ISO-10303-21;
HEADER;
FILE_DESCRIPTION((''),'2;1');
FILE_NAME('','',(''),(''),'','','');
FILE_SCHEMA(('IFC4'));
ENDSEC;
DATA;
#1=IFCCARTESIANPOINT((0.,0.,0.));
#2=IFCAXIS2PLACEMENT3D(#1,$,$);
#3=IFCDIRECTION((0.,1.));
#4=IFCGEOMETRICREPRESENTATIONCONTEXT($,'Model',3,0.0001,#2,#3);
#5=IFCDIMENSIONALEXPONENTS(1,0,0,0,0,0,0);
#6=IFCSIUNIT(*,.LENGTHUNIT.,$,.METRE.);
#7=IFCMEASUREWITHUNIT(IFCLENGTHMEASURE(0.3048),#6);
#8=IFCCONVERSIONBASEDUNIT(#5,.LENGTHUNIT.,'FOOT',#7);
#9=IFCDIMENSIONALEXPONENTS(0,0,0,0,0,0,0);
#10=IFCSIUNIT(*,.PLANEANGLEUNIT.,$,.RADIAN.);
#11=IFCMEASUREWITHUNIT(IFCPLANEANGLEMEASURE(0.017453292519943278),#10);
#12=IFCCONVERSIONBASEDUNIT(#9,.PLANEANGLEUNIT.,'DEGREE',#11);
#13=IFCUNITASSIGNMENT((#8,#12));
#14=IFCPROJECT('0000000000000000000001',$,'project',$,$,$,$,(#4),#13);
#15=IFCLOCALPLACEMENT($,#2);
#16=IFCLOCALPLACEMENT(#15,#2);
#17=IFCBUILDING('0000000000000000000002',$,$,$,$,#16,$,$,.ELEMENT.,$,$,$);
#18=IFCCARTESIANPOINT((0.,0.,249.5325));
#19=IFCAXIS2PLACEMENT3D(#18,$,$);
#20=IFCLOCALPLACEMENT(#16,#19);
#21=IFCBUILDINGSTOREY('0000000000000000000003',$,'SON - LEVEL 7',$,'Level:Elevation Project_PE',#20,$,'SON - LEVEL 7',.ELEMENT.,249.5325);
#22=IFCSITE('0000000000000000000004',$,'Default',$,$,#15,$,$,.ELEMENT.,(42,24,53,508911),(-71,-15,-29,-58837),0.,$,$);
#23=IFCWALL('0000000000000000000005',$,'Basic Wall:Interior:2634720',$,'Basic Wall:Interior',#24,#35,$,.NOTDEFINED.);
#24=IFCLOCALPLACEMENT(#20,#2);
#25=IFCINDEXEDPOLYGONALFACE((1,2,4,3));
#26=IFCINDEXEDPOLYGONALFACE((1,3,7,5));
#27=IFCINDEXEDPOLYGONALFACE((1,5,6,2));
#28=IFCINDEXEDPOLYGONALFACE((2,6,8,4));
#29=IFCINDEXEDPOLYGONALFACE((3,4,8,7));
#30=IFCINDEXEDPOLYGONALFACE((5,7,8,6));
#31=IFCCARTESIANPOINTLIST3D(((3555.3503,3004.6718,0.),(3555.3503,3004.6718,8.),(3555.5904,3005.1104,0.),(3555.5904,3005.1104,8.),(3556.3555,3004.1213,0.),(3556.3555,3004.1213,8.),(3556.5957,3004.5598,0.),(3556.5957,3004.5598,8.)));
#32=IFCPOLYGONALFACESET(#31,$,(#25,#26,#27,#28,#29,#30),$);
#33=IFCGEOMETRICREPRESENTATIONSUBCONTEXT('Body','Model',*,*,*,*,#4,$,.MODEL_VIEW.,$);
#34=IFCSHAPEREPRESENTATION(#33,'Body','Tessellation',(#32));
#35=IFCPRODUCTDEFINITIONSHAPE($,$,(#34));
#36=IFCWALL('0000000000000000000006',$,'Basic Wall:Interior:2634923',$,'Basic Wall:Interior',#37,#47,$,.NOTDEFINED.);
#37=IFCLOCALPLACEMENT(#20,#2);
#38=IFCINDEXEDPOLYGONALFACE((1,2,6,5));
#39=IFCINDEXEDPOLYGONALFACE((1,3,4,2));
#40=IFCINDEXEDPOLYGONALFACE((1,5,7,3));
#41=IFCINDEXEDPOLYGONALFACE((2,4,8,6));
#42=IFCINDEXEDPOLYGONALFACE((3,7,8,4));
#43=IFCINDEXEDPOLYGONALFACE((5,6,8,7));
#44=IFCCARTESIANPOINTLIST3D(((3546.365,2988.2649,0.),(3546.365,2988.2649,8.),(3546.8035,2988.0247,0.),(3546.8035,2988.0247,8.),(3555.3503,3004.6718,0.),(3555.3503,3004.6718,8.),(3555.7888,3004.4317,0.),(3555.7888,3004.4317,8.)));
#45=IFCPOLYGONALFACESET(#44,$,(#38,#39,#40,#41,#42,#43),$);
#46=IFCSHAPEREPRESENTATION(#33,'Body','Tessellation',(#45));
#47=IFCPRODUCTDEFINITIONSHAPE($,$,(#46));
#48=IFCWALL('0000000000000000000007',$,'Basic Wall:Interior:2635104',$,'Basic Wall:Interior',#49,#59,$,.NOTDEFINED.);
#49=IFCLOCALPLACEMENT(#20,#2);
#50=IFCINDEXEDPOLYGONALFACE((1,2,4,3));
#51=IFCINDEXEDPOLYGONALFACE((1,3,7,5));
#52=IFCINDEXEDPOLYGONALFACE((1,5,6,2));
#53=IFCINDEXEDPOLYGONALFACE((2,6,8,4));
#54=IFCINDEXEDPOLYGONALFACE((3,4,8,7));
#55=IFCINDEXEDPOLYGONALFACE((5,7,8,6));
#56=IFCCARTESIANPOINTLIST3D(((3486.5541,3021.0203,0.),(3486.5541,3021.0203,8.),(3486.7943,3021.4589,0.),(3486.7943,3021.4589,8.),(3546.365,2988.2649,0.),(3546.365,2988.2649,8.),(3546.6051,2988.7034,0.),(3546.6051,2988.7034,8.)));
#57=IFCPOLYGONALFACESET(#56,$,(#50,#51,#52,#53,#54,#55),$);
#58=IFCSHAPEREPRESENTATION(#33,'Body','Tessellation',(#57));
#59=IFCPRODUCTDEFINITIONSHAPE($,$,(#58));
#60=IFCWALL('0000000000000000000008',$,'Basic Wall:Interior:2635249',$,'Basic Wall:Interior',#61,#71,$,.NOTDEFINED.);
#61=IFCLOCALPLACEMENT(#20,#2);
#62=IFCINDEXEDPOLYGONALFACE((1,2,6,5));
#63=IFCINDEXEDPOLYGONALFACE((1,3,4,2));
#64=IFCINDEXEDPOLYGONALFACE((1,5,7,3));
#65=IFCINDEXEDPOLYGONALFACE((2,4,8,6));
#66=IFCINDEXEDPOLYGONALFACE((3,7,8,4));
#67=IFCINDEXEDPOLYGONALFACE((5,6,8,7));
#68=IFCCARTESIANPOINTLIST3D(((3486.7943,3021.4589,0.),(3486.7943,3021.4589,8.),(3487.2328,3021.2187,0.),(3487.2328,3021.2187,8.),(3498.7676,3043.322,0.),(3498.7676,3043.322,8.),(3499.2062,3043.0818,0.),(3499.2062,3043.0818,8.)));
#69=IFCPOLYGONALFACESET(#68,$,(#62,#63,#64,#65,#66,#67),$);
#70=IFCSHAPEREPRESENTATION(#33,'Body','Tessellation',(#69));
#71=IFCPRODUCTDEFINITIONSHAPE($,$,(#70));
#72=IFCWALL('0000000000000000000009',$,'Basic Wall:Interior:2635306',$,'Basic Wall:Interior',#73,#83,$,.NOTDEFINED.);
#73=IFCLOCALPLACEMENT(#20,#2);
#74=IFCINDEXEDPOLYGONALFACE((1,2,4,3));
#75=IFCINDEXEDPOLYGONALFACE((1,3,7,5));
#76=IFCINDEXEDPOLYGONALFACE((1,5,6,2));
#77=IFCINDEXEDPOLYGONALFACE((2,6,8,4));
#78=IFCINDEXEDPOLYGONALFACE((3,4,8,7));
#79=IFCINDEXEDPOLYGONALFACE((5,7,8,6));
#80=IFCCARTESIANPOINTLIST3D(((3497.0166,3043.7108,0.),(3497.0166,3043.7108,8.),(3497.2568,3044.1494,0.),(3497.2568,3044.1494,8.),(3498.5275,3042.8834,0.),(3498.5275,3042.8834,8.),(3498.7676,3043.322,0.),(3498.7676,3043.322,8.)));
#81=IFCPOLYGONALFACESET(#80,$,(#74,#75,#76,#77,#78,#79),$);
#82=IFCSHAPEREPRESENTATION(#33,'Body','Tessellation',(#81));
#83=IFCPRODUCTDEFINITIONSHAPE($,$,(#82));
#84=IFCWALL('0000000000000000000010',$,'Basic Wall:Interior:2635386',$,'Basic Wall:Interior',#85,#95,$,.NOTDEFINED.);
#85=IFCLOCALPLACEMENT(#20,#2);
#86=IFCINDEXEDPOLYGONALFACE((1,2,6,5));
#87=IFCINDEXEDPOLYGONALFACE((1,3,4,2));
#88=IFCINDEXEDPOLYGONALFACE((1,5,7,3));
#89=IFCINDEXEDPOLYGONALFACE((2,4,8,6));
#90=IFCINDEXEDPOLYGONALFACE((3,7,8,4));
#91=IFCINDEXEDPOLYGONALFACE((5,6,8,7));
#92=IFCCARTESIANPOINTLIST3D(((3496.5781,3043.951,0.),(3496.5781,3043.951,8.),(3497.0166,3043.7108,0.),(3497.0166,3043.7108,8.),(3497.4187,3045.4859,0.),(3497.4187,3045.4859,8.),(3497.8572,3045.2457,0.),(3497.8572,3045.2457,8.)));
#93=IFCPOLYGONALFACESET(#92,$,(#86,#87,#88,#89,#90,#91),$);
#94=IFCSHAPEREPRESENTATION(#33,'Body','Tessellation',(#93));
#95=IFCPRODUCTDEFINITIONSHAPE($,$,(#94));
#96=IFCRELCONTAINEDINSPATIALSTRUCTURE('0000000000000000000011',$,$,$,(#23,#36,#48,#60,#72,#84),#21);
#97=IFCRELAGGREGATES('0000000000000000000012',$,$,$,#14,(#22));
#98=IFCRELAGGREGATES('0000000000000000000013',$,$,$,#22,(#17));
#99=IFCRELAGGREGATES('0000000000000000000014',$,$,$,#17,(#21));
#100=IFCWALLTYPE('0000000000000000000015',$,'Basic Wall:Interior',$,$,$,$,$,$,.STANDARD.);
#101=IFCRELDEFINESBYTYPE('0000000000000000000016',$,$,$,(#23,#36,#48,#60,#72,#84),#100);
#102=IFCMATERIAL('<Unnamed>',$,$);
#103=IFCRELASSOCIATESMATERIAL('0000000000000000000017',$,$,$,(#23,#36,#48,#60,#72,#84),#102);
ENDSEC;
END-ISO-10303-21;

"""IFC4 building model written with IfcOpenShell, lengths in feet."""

from ifc_helpers import new_model, entity, si_unit, converted_unit, direction, frame, origin, place, context, subcontext, project, spatial, indexed_curve, outline, extrude, material, type_object, element, save


model = new_model("IFC4")

# Units and contexts
model_context = context("Model", 3, precision=0.0001, world=origin(), true_north=direction((0.0, 1.0)))
body_context = subcontext(model_context, "Body", "Model", "MODEL_VIEW")
ifc_project = project(units=[converted_unit("LENGTHUNIT", "FOOT", entity("IfcLengthMeasure", 0.3048), si_unit("LENGTHUNIT", "METRE"), dimensions=[1, 0, 0, 0, 0, 0, 0]), converted_unit("PLANEANGLEUNIT", "DEGREE", entity("IfcPlaneAngleMeasure", 0.017453292519943278), si_unit("PLANEANGLEUNIT", "RADIAN"), dimensions=[0, 0, 0, 0, 0, 0, 0])], contexts=[model_context])

# Site, building, storey
site_placement = place(None, origin())
site = spatial("IfcSite", under=ifc_project, at=site_placement, Name="Default", CompositionType="ELEMENT", RefLatitude=(42, 24, 53, 508911), RefLongitude=(-71, -15, -29, -58837), RefElevation=0.0)
building_placement = place(site_placement, origin())
building = spatial("IfcBuilding", under=site, at=building_placement, CompositionType="ELEMENT")
storey_placement = place(building_placement, frame((0.0, 0.0, 249.5325)))
storey = spatial("IfcBuildingStorey", under=building, at=storey_placement, Name="SON - LEVEL 7", ObjectType="Level:Elevation Project_PE", LongName="SON - LEVEL 7", CompositionType="ELEMENT", Elevation=249.5325)

# Walls
ifc_material = material(Name="<Unnamed>")
wall_type = type_object("IfcWallType", Name="Basic Wall:Interior", PredefinedType="STANDARD")
wall_1_placement = place(storey_placement, frame((3556.4756, 3004.3406, 0.0), z_axis=(0.0, 0.0, 1.0), x_axis=(-0.877084, 0.480336, 0.0)))
element("IfcWall", 1, at=wall_1_placement, inside=storey, type_object=wall_type, material=ifc_material, Name="Basic Wall:Interior:2634720", ObjectType="Basic Wall:Interior", PredefinedType="NOTDEFINED", context=body_context, shape_type="SweptSolid", body=[
    extrude(outline(indexed_curve([(1.1461, 0.25), (0.0, 0.25), (0.0, -0.25), (1.1461, -0.25), (1.1461, 0.25)], self_intersect=False)), origin(), (0.0, 0.0, 1.0), 8.0),
])
wall_2_placement = place(storey_placement, frame((3555.5695, 3004.5517, 0.0), z_axis=(0.0, 0.0, 1.0), x_axis=(-0.480336, -0.877084, 0.0)))
element("IfcWall", 2, at=wall_2_placement, inside=storey, type_object=wall_type, material=ifc_material, Name="Basic Wall:Interior:2634923", ObjectType="Basic Wall:Interior", PredefinedType="NOTDEFINED", context=body_context, shape_type="SweptSolid", body=[
    extrude(outline(indexed_curve([(18.7063, 0.25), (0.0, 0.25), (0.0, -0.25), (18.7063, -0.25), (18.7063, 0.25)], self_intersect=False)), origin(), (0.0, 0.0, 1.0), 8.0),
])
wall_3_placement = place(storey_placement, frame((3546.485, 2988.4841, 0.0), z_axis=(0.0, 0.0, 1.0), x_axis=(-0.877084, 0.480336, 0.0)))
element("IfcWall", 3, at=wall_3_placement, inside=storey, type_object=wall_type, material=ifc_material, Name="Basic Wall:Interior:2635104", ObjectType="Basic Wall:Interior", PredefinedType="NOTDEFINED", context=body_context, shape_type="SweptSolid", body=[
    extrude(outline(indexed_curve([(68.1928, 0.25), (0.0, 0.25), (0.0, -0.25), (68.1928, -0.25), (68.1928, 0.25)], self_intersect=False)), origin(), (0.0, 0.0, 1.0), 8.0),
])
wall_4_placement = place(storey_placement, frame((3487.0136, 3021.3388, 0.0), z_axis=(0.0, 0.0, 1.0), x_axis=(0.480336, 0.877084, 0.0)))
element("IfcWall", 4, at=wall_4_placement, inside=storey, type_object=wall_type, material=ifc_material, Name="Basic Wall:Interior:2635249", ObjectType="Basic Wall:Interior", PredefinedType="NOTDEFINED", context=body_context, shape_type="SweptSolid", body=[
    extrude(outline(indexed_curve([(24.927, 0.25), (0.0, 0.25), (0.0, -0.25), (24.927, -0.25), (24.927, 0.25)], self_intersect=False)), origin(), (0.0, 0.0, 1.0), 8.0),
])
wall_5_placement = place(storey_placement, frame((3498.6476, 3043.1027, 0.0), z_axis=(0.0, 0.0, 1.0), x_axis=(-0.877084, 0.480336, 0.0)))
element("IfcWall", 5, at=wall_5_placement, inside=storey, type_object=wall_type, material=ifc_material, Name="Basic Wall:Interior:2635306", ObjectType="Basic Wall:Interior", PredefinedType="NOTDEFINED", context=body_context, shape_type="SweptSolid", body=[
    extrude(outline(indexed_curve([(1.7226, 0.25), (0.0, 0.25), (0.0, -0.25), (1.7226, -0.25), (1.7226, 0.25)], self_intersect=False)), origin(), (0.0, 0.0, 1.0), 8.0),
])
wall_6_placement = place(storey_placement, frame((3496.7974, 3043.8309, 0.0), z_axis=(0.0, 0.0, 1.0), x_axis=(0.480336, 0.877084, 0.0)))
element("IfcWall", 6, at=wall_6_placement, inside=storey, type_object=wall_type, material=ifc_material, Name="Basic Wall:Interior:2635386", ObjectType="Basic Wall:Interior", PredefinedType="NOTDEFINED", context=body_context, shape_type="SweptSolid", body=[
    extrude(outline(indexed_curve([(1.75, 0.25), (0.0, 0.25), (0.0, -0.25), (1.75, -0.25), (1.75, 0.25)], self_intersect=False)), origin(), (0.0, 0.0, 1.0), 8.0),
])

save(model, "model.ifc")
